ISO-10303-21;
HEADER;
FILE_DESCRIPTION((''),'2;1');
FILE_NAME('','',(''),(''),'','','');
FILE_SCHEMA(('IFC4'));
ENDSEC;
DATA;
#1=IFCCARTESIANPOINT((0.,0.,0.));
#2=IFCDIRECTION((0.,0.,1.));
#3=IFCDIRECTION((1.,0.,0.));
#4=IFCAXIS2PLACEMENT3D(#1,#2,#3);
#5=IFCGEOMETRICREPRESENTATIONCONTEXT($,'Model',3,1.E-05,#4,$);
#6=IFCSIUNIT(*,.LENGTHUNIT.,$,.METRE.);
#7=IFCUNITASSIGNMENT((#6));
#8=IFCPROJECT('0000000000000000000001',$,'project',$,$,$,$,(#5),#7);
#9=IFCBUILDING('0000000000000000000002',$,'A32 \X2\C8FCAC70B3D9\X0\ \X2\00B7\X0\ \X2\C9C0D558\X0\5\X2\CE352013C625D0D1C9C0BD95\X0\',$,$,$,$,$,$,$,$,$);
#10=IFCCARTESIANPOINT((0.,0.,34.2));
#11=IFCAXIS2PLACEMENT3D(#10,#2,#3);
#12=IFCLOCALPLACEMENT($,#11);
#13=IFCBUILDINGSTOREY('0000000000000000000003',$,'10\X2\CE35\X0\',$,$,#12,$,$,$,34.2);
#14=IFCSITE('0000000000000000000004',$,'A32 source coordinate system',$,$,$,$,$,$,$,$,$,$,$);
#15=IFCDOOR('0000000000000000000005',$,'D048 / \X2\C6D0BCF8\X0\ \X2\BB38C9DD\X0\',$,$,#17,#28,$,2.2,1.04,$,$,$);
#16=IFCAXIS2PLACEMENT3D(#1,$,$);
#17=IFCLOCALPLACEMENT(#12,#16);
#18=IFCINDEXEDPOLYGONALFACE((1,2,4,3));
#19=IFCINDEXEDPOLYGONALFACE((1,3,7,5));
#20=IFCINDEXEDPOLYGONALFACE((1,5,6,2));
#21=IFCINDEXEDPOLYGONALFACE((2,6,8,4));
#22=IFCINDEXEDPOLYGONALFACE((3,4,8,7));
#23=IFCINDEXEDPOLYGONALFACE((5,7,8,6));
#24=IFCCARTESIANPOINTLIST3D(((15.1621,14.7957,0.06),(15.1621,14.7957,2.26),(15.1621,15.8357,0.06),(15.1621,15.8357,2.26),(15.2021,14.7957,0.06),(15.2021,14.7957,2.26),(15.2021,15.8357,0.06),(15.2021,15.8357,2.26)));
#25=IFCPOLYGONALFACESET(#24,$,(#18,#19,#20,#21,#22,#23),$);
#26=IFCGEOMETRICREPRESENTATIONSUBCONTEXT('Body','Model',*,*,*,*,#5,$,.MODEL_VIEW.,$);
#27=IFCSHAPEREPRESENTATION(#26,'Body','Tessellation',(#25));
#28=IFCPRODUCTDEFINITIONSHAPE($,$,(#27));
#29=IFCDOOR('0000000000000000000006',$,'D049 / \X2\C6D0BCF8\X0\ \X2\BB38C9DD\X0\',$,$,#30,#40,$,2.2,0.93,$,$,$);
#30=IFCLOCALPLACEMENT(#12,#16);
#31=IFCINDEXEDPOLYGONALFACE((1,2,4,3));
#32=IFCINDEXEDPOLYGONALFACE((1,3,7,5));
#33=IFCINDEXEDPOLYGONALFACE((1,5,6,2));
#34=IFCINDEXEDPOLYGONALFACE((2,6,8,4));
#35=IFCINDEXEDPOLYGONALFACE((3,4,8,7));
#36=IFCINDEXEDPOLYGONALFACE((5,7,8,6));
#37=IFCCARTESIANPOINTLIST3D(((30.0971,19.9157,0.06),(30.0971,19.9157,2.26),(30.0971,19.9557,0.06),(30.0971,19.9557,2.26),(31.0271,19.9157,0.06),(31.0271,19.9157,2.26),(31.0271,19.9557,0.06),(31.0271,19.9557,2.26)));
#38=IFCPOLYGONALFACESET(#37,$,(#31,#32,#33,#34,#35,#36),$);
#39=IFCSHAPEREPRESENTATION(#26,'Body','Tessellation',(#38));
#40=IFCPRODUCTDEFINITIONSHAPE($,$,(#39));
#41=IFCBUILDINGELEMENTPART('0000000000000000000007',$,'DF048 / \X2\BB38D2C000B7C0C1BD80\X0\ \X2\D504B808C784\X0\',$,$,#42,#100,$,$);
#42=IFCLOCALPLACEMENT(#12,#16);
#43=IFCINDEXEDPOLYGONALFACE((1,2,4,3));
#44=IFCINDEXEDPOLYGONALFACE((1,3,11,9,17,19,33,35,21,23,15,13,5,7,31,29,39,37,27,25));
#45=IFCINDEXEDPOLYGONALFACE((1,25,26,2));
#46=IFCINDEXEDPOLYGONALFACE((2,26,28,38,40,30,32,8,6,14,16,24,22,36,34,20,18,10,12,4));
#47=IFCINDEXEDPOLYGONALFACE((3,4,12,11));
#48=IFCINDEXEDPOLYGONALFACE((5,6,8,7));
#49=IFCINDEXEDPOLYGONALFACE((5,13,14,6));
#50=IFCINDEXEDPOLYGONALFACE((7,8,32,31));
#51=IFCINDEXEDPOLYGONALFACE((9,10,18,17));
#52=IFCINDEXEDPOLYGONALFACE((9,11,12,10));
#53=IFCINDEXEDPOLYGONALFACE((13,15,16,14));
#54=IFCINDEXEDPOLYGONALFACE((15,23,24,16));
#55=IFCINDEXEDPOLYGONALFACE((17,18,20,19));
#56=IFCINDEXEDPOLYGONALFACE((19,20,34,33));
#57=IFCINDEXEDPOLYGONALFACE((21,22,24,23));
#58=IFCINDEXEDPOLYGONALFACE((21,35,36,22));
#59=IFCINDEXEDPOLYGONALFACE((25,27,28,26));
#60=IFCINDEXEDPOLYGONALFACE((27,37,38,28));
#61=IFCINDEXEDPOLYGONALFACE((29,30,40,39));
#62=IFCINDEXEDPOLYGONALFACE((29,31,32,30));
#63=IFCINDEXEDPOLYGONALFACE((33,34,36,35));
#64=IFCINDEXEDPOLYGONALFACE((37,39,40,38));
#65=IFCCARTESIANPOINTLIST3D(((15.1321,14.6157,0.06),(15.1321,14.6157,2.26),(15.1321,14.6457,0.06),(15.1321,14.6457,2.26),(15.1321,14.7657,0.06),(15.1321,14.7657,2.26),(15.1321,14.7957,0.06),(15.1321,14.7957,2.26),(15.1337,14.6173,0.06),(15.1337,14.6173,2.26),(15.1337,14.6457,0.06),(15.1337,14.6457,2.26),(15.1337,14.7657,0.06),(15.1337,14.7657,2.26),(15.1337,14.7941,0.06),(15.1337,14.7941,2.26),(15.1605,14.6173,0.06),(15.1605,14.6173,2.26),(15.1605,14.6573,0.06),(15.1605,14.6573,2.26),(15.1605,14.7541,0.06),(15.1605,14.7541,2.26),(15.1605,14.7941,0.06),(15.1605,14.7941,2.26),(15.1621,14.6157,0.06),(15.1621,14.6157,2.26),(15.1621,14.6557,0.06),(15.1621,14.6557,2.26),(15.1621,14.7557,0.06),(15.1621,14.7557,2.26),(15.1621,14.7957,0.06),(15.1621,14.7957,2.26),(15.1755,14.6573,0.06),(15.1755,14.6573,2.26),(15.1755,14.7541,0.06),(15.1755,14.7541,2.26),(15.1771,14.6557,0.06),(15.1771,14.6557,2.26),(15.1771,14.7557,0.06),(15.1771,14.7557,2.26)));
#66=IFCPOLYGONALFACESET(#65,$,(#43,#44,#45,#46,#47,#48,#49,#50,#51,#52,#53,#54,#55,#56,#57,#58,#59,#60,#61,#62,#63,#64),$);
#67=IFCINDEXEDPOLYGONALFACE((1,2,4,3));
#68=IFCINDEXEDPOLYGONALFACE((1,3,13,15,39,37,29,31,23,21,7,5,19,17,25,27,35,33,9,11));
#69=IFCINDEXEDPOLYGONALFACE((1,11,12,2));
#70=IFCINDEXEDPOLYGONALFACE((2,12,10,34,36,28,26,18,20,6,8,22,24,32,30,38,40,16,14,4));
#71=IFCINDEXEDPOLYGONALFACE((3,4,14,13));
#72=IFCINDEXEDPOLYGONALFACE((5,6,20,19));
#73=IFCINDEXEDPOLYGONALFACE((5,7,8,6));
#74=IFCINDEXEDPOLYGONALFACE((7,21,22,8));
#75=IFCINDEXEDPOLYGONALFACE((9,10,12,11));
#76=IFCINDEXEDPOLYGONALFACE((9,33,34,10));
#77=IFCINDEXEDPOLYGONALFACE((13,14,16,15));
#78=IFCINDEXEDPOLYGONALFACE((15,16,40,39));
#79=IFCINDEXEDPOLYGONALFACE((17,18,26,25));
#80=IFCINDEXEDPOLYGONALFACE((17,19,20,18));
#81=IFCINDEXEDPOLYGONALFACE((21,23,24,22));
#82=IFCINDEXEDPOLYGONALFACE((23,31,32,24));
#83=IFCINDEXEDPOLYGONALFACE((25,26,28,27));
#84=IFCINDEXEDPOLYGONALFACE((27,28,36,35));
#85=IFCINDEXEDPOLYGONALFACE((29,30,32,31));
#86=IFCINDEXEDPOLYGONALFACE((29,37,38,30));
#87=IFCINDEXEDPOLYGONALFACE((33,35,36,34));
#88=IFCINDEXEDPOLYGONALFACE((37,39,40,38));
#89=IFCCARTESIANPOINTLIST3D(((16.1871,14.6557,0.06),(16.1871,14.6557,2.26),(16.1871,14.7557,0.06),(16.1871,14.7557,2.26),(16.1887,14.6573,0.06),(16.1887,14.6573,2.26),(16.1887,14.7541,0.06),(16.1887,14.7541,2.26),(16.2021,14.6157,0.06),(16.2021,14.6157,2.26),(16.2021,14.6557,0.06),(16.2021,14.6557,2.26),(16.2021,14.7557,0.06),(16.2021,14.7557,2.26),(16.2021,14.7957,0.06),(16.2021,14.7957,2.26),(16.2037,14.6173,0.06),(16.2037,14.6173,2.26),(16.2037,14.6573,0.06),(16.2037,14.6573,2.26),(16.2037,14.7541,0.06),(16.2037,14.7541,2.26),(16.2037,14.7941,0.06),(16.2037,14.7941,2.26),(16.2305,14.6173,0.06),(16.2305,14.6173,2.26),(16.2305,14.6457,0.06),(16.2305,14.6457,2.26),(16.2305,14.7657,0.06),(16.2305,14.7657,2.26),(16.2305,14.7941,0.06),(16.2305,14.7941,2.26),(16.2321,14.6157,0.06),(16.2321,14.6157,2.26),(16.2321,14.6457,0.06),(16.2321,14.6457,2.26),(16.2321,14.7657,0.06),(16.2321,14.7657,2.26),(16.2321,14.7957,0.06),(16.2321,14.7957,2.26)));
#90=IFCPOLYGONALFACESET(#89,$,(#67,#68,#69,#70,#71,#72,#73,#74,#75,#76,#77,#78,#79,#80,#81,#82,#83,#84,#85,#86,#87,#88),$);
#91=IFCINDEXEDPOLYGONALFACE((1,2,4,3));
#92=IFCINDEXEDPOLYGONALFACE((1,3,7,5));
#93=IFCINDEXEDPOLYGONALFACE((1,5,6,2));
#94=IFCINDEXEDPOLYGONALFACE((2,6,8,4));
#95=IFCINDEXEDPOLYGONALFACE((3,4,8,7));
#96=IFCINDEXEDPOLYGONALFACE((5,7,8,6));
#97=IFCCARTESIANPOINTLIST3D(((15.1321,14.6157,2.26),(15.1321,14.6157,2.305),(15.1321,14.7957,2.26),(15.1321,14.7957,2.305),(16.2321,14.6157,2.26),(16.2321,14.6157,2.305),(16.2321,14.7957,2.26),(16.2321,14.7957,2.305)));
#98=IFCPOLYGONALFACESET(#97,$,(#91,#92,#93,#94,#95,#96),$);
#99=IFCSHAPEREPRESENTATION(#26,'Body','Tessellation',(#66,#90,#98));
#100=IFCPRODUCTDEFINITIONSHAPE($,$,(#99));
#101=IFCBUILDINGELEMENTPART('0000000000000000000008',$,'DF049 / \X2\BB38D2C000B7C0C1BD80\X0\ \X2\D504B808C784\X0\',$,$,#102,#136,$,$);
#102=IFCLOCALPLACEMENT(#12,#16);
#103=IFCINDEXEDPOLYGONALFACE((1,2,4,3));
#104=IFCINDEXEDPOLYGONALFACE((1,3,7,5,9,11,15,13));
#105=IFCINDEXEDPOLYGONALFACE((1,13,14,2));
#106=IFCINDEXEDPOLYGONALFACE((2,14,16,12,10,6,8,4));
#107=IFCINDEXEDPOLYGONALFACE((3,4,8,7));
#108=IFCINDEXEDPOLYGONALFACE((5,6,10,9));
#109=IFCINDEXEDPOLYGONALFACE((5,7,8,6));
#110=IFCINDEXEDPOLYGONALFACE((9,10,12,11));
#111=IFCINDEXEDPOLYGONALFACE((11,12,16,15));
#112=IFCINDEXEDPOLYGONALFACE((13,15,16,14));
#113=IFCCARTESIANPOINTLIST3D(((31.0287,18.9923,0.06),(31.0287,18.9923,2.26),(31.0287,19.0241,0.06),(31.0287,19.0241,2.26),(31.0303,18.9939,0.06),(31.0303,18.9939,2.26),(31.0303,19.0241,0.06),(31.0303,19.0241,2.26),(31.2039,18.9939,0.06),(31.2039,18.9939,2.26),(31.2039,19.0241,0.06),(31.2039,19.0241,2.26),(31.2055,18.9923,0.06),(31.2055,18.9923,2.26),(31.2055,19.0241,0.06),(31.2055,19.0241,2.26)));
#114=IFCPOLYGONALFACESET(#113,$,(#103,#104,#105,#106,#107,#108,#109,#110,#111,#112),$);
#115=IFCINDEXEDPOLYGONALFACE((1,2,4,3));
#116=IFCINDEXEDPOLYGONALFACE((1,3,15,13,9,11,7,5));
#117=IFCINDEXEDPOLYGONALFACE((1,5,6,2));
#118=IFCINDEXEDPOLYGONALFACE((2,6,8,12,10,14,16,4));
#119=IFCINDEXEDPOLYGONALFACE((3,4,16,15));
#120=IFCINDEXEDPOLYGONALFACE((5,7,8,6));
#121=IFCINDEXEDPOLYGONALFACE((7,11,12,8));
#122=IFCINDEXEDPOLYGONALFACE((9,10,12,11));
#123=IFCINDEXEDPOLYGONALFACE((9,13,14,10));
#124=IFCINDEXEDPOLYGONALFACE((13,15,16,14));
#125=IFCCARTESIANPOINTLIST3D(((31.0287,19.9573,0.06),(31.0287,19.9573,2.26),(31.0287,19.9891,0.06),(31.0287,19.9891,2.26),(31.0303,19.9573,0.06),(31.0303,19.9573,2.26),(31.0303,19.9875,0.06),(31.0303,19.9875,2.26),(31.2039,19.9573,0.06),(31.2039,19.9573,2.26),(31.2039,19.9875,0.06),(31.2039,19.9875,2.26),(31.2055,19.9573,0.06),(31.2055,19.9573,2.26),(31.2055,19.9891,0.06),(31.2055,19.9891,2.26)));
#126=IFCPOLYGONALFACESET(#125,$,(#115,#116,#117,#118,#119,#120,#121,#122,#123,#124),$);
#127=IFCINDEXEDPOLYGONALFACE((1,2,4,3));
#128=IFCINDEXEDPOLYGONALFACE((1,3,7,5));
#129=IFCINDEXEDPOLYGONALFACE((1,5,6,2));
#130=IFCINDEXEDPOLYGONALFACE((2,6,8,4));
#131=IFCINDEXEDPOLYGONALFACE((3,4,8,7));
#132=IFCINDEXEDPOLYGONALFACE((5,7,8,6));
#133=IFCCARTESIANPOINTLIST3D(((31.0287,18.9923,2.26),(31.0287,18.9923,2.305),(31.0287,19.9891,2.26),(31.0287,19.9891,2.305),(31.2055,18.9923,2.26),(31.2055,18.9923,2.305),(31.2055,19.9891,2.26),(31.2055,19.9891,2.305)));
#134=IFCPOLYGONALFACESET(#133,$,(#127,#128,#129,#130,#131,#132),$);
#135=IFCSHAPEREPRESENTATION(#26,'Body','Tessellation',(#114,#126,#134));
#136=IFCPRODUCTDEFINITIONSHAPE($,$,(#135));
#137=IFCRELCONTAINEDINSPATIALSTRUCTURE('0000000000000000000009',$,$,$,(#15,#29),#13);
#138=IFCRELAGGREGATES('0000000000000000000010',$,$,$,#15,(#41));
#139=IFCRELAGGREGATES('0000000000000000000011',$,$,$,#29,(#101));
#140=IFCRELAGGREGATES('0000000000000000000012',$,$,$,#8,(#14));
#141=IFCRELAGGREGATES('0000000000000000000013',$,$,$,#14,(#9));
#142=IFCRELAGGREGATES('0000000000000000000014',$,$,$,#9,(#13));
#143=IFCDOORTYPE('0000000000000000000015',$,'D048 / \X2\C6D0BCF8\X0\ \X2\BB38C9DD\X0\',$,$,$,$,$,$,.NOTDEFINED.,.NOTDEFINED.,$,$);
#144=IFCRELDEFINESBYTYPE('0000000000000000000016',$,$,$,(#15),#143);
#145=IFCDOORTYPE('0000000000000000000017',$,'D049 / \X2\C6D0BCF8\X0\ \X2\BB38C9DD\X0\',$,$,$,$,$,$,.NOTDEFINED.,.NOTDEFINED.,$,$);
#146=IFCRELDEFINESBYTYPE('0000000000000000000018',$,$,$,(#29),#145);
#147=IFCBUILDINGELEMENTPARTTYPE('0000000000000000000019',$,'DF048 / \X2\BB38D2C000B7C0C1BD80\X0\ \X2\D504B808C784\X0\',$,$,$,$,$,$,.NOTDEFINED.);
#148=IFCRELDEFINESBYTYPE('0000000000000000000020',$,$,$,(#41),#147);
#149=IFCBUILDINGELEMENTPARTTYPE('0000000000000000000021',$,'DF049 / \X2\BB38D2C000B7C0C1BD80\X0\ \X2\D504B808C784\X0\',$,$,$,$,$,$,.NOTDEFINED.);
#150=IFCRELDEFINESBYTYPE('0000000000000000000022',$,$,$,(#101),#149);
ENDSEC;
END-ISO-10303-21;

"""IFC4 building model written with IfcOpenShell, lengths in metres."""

from ifc_helpers import new_model, si_unit, frame, origin, origin_with_axes, place, context, subcontext, project, spatial, polyline, outline, extrude, source, transform, mapped, type_object, type_shapes, element, aggregate, save


model = new_model("IFC4")

# Units and contexts
model_context = context("Model", 3, precision=1e-05, world=origin_with_axes())
body_context = subcontext(model_context, "Body", "Model", "MODEL_VIEW")
ifc_project = project(units=[si_unit("LENGTHUNIT", "METRE")], contexts=[model_context])

# Site, building, storey
storey_placement = place(None, frame((0.0, 0.0, 34.2), z_axis=(0.0, 0.0, 1.0), x_axis=(1.0, 0.0, 0.0)))
site = spatial("IfcSite", under=ifc_project, Name="A32 source coordinate system")
building = spatial("IfcBuilding", under=site, Name="A32 주거동 · 지하5층–옥탑지붕")
storey = spatial("IfcBuildingStorey", under=building, at=storey_placement, Name="10층", Elevation=34.2)

# Doors
door_type_1 = type_object("IfcDoorType", Name="D048 / 원본 문짝", OperationType="NOTDEFINED", PredefinedType="NOTDEFINED")
shared_shape_1 = source(origin(), body_context, "Body", "SweptSolid", [
    extrude(outline(polyline([(15.2021, 15.8357), (15.2021, 14.7957), (15.1621, 14.7957), (15.1621, 15.8357), (15.2021, 15.8357)])), frame((0.0, 0.0, 0.06)), (0.0, 0.0, 1.0), 2.2),
])
type_shapes(door_type_1, [shared_shape_1])
door_1_placement = place(storey_placement, origin_with_axes())
door_1 = element("IfcDoor", 1, at=door_1_placement, inside=storey, type_object=door_type_1, Name="D048 / 원본 문짝", OverallHeight=2.2, OverallWidth=1.04, context=body_context, shape_type="MappedRepresentation", body=[
    mapped(shared_shape_1, transform((0.0, 0.0, 0.0), scale=1.0)),
])
door_type_2 = type_object("IfcDoorType", Name="D049 / 원본 문짝", OperationType="NOTDEFINED", PredefinedType="NOTDEFINED")
shared_shape_2 = source(origin(), body_context, "Body", "SweptSolid", [
    extrude(outline(polyline([(31.0271, 19.9557), (31.0271, 19.9157), (30.0971, 19.9157), (30.0971, 19.9557), (31.0271, 19.9557)])), frame((0.0, 0.0, 0.06)), (0.0, 0.0, 1.0), 2.2),
])
type_shapes(door_type_2, [shared_shape_2])
door_2_placement = place(storey_placement, origin_with_axes())
door_2 = element("IfcDoor", 2, at=door_2_placement, inside=storey, type_object=door_type_2, Name="D049 / 원본 문짝", OverallHeight=2.2, OverallWidth=0.93, context=body_context, shape_type="MappedRepresentation", body=[
    mapped(shared_shape_2, transform((0.0, 0.0, 0.0), scale=1.0)),
])

# Building element parts
building_element_part_type_1 = type_object("IfcBuildingElementPartType", Name="DF048 / 문틀·상부 프레임", PredefinedType="NOTDEFINED")
shared_shape_3 = source(origin(), body_context, "Body", "SweptSolid", [
    extrude(outline(polyline([(15.1321, 14.7657), (15.1321, 14.7957), (15.1621, 14.7957), (15.1621, 14.7557), (15.1771, 14.7557), (15.1771, 14.6557), (15.1621, 14.6557), (15.1621, 14.6157), (15.1321, 14.6157), (15.1321, 14.6457), (15.1337, 14.6457), (15.1337, 14.6173), (15.1605, 14.6173), (15.1605, 14.6573), (15.1755, 14.6573), (15.1755, 14.7541), (15.1605, 14.7541), (15.1605, 14.7941), (15.1337, 14.7941), (15.1337, 14.7657), (15.1321, 14.7657)])), frame((0.0, 0.0, 0.06)), (0.0, 0.0, 1.0), 2.2),
    extrude(outline(polyline([(16.2305, 14.7941), (16.2037, 14.7941), (16.2037, 14.7541), (16.1887, 14.7541), (16.1887, 14.6573), (16.2037, 14.6573), (16.2037, 14.6173), (16.2305, 14.6173), (16.2305, 14.6457), (16.2321, 14.6457), (16.2321, 14.6157), (16.2021, 14.6157), (16.2021, 14.6557), (16.1871, 14.6557), (16.1871, 14.7557), (16.2021, 14.7557), (16.2021, 14.7957), (16.2321, 14.7957), (16.2321, 14.7657), (16.2305, 14.7657), (16.2305, 14.7941)])), frame((0.0, 0.0, 0.06)), (0.0, 0.0, 1.0), 2.2),
    extrude(outline(polyline([(15.1321, 14.6157), (15.1321, 14.7957), (16.2321, 14.7957), (16.2321, 14.6157), (15.1321, 14.6157)])), frame((0.0, 0.0, 2.26)), (0.0, 0.0, 1.0), 0.045),
])
type_shapes(building_element_part_type_1, [shared_shape_3])
building_element_part_1_placement = place(door_1_placement, origin_with_axes())
building_element_part_1 = element("IfcBuildingElementPart", 3, at=building_element_part_1_placement, type_object=building_element_part_type_1, Name="DF048 / 문틀·상부 프레임", context=body_context, shape_type="MappedRepresentation", body=[
    mapped(shared_shape_3, transform((0.0, 0.0, 0.0), scale=1.0)),
])
aggregate(door_1, [building_element_part_1])
building_element_part_type_2 = type_object("IfcBuildingElementPartType", Name="DF049 / 문틀·상부 프레임", PredefinedType="NOTDEFINED")
shared_shape_4 = source(origin(), body_context, "Body", "SweptSolid", [
    extrude(outline(polyline([(31.0303, 19.0241), (31.0303, 18.9939), (31.2039, 18.9939), (31.2039, 19.0241), (31.2055, 19.0241), (31.2055, 18.9923), (31.0287, 18.9923), (31.0287, 19.0241), (31.0303, 19.0241)])), frame((0.0, 0.0, 0.06)), (0.0, 0.0, 1.0), 2.2),
    extrude(outline(polyline([(31.0287, 19.9891), (31.2055, 19.9891), (31.2055, 19.9573), (31.2039, 19.9573), (31.2039, 19.9875), (31.0303, 19.9875), (31.0303, 19.9573), (31.0287, 19.9573), (31.0287, 19.9891)])), frame((0.0, 0.0, 0.06)), (0.0, 0.0, 1.0), 2.2),
    extrude(outline(polyline([(31.0287, 18.9923), (31.0287, 19.9891), (31.2055, 19.9891), (31.2055, 18.9923), (31.0287, 18.9923)])), frame((0.0, 0.0, 2.26)), (0.0, 0.0, 1.0), 0.045),
])
type_shapes(building_element_part_type_2, [shared_shape_4])
building_element_part_2_placement = place(door_2_placement, origin_with_axes())
building_element_part_2 = element("IfcBuildingElementPart", 4, at=building_element_part_2_placement, type_object=building_element_part_type_2, Name="DF049 / 문틀·상부 프레임", context=body_context, shape_type="MappedRepresentation", body=[
    mapped(shared_shape_4, transform((0.0, 0.0, 0.0), scale=1.0)),
])
aggregate(door_2, [building_element_part_2])

save(model, "model.ifc")
